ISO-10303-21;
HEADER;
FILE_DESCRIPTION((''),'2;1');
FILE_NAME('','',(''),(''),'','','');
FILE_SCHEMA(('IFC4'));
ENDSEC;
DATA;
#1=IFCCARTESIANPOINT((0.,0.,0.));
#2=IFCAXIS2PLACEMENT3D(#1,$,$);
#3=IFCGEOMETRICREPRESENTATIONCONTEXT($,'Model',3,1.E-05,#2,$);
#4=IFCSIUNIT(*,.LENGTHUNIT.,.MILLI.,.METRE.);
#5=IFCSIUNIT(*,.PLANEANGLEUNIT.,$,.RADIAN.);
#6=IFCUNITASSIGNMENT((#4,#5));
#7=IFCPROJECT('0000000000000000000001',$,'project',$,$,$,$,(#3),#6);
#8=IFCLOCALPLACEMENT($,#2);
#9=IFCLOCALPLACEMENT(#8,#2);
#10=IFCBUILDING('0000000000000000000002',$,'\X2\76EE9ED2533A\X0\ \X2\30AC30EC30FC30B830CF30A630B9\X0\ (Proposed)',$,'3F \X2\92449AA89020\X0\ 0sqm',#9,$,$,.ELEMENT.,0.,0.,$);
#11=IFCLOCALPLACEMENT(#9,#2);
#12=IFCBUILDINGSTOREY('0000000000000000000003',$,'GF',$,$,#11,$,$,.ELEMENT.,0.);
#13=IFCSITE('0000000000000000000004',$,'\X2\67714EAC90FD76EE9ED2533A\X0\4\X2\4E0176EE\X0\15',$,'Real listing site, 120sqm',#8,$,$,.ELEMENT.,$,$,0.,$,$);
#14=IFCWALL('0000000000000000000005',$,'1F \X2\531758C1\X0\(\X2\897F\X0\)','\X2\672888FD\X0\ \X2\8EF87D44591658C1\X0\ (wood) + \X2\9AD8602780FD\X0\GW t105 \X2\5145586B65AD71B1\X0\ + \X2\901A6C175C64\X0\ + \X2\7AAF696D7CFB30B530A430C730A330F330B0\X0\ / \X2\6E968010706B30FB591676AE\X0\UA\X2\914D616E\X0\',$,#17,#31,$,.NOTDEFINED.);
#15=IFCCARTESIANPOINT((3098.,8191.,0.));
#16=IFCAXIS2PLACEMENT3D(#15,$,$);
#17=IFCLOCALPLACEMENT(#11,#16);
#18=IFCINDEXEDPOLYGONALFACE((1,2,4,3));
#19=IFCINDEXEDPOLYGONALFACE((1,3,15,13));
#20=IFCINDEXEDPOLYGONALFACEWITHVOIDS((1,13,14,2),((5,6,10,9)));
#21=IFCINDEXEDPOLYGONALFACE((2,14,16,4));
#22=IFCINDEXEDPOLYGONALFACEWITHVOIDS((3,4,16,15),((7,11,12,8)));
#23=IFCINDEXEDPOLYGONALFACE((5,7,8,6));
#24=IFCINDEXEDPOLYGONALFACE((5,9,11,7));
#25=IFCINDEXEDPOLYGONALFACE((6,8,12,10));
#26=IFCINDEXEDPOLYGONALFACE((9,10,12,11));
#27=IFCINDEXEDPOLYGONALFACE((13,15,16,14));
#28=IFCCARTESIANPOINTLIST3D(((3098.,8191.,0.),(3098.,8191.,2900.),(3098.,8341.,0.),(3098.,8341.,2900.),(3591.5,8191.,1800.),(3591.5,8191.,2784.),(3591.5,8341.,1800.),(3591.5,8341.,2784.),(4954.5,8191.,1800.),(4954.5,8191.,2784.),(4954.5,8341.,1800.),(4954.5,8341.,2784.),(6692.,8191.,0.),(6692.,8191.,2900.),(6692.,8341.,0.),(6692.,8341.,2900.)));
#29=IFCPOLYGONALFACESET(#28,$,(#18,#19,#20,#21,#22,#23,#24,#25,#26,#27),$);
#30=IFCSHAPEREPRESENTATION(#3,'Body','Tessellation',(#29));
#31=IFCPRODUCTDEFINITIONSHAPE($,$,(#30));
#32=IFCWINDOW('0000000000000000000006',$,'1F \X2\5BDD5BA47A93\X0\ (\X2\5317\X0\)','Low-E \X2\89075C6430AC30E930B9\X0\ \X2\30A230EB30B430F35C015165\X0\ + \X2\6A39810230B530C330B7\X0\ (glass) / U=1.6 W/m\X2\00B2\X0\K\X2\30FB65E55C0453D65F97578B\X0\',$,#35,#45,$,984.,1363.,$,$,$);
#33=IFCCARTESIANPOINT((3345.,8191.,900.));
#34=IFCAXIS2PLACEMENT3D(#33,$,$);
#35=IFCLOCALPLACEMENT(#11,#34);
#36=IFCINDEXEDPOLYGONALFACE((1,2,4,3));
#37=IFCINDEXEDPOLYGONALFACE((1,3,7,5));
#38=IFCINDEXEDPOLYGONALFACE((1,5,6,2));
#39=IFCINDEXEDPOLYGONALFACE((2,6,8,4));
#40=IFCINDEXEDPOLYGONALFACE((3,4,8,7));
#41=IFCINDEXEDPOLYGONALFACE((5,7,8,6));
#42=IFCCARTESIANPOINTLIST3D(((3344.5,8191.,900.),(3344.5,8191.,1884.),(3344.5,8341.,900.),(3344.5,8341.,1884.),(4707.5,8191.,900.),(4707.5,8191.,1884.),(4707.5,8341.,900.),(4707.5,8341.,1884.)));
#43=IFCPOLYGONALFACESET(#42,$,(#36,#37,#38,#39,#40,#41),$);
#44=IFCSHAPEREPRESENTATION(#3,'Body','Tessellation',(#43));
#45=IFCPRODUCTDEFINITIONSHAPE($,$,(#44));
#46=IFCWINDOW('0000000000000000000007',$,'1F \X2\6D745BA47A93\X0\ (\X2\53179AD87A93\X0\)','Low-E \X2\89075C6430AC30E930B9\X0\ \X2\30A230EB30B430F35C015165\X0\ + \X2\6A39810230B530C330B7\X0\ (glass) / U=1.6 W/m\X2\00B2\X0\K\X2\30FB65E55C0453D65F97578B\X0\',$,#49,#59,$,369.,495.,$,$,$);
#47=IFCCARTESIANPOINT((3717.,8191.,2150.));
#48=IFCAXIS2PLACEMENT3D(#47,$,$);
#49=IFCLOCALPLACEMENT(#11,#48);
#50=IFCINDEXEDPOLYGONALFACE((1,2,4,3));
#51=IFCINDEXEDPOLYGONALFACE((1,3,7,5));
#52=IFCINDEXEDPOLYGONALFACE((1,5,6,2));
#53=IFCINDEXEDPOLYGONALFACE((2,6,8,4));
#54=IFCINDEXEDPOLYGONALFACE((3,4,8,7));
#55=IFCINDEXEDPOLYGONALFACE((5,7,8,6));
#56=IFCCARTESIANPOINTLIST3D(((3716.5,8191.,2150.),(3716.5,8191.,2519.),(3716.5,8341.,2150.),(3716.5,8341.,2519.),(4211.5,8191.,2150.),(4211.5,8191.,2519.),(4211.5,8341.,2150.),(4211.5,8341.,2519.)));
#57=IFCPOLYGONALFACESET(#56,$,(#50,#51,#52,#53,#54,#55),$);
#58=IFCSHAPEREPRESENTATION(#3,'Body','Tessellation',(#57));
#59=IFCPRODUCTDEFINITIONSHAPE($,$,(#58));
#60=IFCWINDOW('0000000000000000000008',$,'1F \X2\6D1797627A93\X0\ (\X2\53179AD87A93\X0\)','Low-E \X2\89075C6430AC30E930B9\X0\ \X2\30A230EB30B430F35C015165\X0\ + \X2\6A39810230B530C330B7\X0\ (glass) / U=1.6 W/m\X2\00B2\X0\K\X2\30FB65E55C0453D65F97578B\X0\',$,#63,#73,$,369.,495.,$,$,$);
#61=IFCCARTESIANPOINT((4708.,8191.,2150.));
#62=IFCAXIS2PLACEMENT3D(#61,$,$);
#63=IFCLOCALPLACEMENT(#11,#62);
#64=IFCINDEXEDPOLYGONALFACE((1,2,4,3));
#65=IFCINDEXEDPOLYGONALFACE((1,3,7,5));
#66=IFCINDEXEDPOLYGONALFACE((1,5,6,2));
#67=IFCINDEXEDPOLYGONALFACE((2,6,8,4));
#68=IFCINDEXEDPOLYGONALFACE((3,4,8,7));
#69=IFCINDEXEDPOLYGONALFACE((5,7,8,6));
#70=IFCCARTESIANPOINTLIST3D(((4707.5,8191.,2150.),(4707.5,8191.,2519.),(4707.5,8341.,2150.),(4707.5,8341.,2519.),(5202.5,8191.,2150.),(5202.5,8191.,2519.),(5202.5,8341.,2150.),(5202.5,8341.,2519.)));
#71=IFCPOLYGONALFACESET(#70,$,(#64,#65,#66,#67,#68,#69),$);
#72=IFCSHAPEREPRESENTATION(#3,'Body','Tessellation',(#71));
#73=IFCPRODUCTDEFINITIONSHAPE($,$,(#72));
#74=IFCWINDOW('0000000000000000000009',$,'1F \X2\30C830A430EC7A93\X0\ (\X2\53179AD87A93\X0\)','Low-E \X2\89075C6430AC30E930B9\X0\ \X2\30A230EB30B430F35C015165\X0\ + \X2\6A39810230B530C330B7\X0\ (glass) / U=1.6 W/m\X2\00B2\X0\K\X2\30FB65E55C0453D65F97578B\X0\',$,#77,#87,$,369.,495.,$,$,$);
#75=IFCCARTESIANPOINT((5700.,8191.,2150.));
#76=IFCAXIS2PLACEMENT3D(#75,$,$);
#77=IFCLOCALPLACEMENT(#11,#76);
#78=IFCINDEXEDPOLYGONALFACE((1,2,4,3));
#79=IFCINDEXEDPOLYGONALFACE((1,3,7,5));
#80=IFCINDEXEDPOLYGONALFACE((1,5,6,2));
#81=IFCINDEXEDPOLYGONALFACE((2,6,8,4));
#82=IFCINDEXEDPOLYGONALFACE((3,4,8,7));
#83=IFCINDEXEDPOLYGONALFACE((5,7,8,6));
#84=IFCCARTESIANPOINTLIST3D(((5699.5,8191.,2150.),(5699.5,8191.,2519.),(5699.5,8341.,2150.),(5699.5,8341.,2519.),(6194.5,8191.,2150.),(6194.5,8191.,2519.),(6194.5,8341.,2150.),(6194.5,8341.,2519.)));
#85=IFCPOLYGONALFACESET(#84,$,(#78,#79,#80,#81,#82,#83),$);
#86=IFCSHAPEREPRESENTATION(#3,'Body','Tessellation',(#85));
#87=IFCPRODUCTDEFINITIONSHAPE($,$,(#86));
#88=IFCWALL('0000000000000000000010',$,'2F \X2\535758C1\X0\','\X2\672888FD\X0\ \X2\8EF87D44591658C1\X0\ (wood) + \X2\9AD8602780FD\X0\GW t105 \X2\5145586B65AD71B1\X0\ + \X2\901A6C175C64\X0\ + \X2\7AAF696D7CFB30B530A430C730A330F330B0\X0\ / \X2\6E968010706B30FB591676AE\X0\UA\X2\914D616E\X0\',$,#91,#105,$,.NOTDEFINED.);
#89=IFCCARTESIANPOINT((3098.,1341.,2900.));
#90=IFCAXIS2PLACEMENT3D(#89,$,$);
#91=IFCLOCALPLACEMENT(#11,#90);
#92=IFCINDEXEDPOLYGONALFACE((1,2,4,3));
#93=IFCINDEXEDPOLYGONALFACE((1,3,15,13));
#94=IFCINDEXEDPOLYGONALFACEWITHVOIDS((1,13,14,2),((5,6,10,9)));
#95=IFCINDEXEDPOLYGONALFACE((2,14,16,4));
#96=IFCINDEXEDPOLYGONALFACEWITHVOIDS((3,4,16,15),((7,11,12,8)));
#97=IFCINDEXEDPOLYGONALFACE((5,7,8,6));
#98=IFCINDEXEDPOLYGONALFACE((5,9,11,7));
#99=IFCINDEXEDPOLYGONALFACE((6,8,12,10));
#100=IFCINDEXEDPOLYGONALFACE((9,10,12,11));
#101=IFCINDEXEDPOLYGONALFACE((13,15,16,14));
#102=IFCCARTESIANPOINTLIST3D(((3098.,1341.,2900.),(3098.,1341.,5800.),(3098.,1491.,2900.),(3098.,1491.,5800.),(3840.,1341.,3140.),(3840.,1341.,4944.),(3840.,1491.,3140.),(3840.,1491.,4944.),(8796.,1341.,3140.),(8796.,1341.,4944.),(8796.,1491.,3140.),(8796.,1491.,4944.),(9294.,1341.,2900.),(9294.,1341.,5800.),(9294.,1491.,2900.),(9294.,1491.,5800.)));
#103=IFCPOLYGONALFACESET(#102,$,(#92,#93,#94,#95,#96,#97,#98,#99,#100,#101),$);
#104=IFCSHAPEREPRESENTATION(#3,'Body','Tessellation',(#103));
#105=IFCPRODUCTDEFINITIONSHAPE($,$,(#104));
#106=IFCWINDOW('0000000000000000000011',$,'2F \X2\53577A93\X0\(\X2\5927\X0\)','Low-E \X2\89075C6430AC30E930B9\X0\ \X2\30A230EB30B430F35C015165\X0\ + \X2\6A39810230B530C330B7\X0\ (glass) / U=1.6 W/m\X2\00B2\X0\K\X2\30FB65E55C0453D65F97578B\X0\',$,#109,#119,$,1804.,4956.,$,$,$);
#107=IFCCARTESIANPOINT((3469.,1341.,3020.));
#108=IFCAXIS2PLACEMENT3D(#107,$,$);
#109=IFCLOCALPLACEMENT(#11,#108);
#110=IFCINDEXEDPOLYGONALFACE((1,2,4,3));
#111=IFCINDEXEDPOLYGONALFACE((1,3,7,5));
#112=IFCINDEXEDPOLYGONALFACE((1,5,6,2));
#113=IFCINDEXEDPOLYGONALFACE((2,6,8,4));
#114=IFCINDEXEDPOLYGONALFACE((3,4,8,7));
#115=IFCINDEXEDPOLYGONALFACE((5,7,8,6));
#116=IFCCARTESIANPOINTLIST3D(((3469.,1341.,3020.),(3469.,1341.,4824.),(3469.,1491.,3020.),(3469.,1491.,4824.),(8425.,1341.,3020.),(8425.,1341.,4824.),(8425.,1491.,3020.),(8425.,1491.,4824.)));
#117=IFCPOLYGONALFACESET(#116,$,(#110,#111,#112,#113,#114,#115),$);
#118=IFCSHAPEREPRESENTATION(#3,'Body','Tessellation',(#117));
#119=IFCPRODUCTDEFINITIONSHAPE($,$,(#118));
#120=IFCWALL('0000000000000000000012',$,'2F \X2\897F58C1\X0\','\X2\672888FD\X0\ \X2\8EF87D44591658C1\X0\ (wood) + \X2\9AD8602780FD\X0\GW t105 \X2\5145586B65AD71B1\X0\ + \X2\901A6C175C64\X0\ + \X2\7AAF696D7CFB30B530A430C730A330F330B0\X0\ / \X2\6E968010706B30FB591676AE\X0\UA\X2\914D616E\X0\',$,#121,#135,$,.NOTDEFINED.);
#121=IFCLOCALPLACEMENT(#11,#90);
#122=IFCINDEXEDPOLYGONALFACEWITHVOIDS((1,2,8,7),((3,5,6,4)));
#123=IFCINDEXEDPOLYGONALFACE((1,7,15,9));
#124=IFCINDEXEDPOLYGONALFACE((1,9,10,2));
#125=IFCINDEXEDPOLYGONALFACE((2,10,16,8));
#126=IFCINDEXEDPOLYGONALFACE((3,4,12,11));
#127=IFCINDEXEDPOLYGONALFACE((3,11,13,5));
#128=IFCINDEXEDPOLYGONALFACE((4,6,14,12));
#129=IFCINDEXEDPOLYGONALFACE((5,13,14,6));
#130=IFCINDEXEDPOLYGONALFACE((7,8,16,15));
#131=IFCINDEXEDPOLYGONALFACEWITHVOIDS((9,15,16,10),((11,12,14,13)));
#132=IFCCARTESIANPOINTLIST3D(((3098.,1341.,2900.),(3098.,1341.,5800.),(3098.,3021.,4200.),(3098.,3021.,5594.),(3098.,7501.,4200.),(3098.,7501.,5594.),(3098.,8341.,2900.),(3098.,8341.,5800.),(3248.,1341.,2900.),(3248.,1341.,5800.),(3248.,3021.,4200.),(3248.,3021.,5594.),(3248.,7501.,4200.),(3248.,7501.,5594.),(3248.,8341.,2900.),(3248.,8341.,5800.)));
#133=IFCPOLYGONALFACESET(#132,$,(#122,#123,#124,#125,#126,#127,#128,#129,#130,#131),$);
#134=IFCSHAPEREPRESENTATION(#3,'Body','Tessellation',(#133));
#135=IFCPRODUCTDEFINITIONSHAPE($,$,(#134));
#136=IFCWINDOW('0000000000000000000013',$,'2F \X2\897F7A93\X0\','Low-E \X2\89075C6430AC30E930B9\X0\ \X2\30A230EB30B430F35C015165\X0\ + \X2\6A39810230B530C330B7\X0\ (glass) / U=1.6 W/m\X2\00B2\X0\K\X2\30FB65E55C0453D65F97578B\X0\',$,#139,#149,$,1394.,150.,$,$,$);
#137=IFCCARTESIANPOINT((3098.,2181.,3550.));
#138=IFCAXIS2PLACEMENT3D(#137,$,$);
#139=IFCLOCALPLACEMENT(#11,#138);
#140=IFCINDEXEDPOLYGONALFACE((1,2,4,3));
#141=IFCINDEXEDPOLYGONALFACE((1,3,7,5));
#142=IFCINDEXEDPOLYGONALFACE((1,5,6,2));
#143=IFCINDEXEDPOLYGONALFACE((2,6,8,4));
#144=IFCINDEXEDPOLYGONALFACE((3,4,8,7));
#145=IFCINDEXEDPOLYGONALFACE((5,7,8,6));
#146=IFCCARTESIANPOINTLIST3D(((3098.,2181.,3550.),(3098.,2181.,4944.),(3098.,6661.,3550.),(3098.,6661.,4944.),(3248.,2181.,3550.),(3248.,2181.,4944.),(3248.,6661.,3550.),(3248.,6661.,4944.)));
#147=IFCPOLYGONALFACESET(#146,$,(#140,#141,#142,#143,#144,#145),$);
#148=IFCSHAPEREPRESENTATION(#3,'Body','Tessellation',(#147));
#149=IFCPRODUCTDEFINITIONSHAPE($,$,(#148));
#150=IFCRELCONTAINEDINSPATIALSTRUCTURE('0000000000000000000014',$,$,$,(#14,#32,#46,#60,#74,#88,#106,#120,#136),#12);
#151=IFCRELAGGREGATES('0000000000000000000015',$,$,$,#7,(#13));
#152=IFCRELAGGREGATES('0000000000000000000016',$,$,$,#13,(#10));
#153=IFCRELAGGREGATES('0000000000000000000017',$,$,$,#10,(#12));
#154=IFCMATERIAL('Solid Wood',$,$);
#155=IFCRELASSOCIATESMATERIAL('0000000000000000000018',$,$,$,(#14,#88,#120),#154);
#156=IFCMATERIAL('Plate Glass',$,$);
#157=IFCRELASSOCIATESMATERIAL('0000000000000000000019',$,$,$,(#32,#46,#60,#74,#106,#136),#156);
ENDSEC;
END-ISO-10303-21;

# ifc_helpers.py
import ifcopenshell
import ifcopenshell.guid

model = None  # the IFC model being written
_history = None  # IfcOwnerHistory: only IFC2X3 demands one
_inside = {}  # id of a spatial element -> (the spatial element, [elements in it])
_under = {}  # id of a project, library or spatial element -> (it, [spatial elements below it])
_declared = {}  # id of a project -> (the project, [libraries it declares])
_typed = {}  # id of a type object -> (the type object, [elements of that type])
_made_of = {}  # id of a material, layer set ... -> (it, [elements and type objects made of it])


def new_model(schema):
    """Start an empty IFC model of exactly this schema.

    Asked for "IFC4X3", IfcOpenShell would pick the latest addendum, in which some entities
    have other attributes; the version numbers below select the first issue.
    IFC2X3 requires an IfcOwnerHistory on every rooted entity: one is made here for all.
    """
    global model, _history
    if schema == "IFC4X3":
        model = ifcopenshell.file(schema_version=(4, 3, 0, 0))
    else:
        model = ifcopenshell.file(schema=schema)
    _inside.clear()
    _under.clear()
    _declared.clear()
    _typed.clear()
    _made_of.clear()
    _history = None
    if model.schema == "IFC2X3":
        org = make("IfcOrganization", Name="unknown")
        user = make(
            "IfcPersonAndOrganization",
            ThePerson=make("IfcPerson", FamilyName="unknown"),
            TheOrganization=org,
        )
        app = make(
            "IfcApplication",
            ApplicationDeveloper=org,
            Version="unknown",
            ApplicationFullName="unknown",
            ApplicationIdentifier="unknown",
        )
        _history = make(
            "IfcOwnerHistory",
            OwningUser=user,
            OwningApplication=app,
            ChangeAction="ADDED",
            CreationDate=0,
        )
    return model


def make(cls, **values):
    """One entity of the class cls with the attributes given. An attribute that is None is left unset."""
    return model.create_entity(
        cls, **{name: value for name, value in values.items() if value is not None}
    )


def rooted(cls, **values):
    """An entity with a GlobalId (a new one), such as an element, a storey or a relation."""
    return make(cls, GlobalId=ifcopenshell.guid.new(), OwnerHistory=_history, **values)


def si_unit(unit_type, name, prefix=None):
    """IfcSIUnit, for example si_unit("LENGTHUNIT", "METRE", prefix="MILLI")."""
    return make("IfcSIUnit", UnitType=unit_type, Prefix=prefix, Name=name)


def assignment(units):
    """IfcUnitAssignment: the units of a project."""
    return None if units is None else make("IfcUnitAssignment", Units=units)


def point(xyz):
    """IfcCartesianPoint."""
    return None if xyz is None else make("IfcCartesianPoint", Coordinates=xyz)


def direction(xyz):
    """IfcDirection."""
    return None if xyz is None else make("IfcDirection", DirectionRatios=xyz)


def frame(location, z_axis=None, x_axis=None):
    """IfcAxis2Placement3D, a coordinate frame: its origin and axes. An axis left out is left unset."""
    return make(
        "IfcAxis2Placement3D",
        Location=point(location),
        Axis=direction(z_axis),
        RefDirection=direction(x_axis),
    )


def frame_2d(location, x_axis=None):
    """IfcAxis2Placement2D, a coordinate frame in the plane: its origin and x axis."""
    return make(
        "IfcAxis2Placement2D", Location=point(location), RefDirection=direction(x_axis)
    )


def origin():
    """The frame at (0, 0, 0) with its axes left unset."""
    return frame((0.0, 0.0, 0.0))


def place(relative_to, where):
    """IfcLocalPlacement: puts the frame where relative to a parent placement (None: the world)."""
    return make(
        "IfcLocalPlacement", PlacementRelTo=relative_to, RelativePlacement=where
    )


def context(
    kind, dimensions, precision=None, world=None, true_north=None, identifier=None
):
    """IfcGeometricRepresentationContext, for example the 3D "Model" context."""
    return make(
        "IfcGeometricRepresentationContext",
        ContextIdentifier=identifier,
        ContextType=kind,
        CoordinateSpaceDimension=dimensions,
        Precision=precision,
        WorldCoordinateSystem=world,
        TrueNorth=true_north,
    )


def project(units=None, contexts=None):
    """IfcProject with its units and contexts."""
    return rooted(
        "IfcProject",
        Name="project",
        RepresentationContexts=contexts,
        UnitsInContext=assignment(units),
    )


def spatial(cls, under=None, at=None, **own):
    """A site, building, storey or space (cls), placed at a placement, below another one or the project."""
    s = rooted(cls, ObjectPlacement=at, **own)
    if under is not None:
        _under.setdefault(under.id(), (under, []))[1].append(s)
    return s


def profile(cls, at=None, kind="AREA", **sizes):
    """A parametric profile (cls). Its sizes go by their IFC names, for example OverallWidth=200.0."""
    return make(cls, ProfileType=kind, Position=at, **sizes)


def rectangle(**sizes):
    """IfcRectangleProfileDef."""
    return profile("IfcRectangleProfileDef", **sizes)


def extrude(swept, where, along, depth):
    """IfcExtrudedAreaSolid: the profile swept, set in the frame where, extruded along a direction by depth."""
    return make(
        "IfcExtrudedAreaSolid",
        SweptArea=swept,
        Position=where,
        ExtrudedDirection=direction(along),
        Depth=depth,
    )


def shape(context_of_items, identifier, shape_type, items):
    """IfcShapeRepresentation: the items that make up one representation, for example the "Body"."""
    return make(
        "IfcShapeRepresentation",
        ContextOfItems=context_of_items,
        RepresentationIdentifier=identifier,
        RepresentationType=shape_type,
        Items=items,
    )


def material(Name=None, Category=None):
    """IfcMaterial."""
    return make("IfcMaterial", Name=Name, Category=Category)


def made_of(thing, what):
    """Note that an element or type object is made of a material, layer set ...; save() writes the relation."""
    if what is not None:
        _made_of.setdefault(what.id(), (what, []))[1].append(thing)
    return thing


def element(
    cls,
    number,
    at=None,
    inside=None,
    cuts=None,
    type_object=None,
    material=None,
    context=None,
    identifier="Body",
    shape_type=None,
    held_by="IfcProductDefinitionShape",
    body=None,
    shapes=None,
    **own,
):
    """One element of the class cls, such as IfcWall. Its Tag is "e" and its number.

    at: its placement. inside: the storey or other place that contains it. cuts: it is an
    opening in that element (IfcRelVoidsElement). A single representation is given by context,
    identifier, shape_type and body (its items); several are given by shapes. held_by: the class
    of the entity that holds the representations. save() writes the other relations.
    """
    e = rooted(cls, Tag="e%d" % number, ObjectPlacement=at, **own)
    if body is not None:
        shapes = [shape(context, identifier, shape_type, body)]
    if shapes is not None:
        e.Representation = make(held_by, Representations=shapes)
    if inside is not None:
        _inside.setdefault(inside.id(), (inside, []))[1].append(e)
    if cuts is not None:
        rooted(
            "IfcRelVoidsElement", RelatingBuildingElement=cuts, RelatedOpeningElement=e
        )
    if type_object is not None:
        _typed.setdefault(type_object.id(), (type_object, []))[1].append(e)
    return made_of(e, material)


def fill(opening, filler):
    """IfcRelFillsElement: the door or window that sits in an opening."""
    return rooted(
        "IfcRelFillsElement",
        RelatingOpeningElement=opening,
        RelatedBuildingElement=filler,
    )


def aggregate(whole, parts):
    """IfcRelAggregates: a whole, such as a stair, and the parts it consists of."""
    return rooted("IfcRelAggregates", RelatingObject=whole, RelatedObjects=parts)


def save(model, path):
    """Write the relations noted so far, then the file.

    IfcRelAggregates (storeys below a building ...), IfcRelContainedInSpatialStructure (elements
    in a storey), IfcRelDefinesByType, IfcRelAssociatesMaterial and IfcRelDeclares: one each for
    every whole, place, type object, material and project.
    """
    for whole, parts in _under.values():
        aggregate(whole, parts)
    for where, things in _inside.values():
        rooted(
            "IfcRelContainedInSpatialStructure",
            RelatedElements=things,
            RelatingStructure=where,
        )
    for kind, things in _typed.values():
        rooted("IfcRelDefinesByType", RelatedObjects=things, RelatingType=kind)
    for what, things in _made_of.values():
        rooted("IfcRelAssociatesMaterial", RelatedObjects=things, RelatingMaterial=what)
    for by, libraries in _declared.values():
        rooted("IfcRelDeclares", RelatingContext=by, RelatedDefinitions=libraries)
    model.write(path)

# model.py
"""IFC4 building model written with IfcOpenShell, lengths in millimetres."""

from ifc_helpers import new_model, si_unit, frame, frame_2d, origin, place, context, project, spatial, rectangle, extrude, material, element, fill, save


model = new_model("IFC4")

# Units and contexts
model_context = context("Model", 3, precision=1e-05, world=origin())
ifc_project = project(units=[si_unit("LENGTHUNIT", "METRE", prefix="MILLI"), si_unit("PLANEANGLEUNIT", "RADIAN")], contexts=[model_context])

# Site, building, storey
site_placement = place(None, origin())
site = spatial("IfcSite", under=ifc_project, at=site_placement, Name="東京都目黒区4丁目15", ObjectType="Real listing site, 120sqm", CompositionType="ELEMENT", RefElevation=0.0)
building_placement = place(site_placement, origin())
building = spatial("IfcBuilding", under=site, at=building_placement, Name="目黒区 ガレージハウス (Proposed)", ObjectType="3F 鉄骨造 0sqm", CompositionType="ELEMENT", ElevationOfRefHeight=0.0, ElevationOfTerrain=0.0)
storey_placement = place(building_placement, origin())
storey = spatial("IfcBuildingStorey", under=building, at=storey_placement, Name="GF", CompositionType="ELEMENT", Elevation=0.0)

# Shared definitions
ifc_material_1 = material(Name="Solid Wood")

# Shared definitions
ifc_material_2 = material(Name="Plate Glass")

# Wall, openings, windows
wall_1_placement = place(storey_placement, frame((3098.0, 8191.0, 0.0)))
wall_1 = element("IfcWall", 1, at=wall_1_placement, inside=storey, material=ifc_material_1, Name="1F 北壁(西)", Description="木製 軸組外壁 (wood) + 高性能GW t105 充填断熱 + 通気層 + 窯業系サイディング / 準耐火・外皮UA配慮", PredefinedType="NOTDEFINED", context=model_context, shape_type="SweptSolid", body=[
    extrude(rectangle(XDim=3594.0, YDim=150.0, at=frame_2d((1797.0, 75.0))), frame((3098.0, 8191.0, 0.0)), (0.0, 0.0, 1.0), 2900.0),
])
opening_1_placement = place(storey_placement, frame((3345.0, 8191.0, 900.0)))
opening_1 = element("IfcOpeningElement", 2, at=opening_1_placement, cuts=wall_1, PredefinedType="NOTDEFINED", context=model_context, shape_type="SweptSolid", body=[
    extrude(rectangle(XDim=1363.0, YDim=150.0, at=frame_2d((681.0, 75.0))), frame((3345.0, 8191.0, 900.0)), (0.0, 0.0, 1.0), 984.0),
])
opening_2_placement = place(storey_placement, frame((3717.0, 8191.0, 2150.0)))
opening_2 = element("IfcOpeningElement", 3, at=opening_2_placement, cuts=wall_1, PredefinedType="NOTDEFINED", context=model_context, shape_type="SweptSolid", body=[
    extrude(rectangle(XDim=495.0, YDim=150.0, at=frame_2d((247.0, 75.0))), frame((3717.0, 8191.0, 2150.0)), (0.0, 0.0, 1.0), 369.0),
])
opening_3_placement = place(storey_placement, frame((4708.0, 8191.0, 2150.0)))
opening_3 = element("IfcOpeningElement", 4, at=opening_3_placement, cuts=wall_1, PredefinedType="NOTDEFINED", context=model_context, shape_type="SweptSolid", body=[
    extrude(rectangle(XDim=495.0, YDim=150.0, at=frame_2d((247.0, 75.0))), frame((4708.0, 8191.0, 2150.0)), (0.0, 0.0, 1.0), 369.0),
])
opening_4_placement = place(storey_placement, frame((5700.0, 8191.0, 2150.0)))
opening_4 = element("IfcOpeningElement", 5, at=opening_4_placement, cuts=wall_1, PredefinedType="NOTDEFINED", context=model_context, shape_type="SweptSolid", body=[
    extrude(rectangle(XDim=495.0, YDim=150.0, at=frame_2d((247.0, 75.0))), frame((5700.0, 8191.0, 2150.0)), (0.0, 0.0, 1.0), 369.0),
])
window_1_placement = place(storey_placement, frame((3345.0, 8191.0, 900.0)))
window_1 = element("IfcWindow", 6, at=window_1_placement, inside=storey, material=ifc_material_2, Name="1F 寝室窓 (北)", Description="Low-E 複層ガラス アルゴン封入 + 樹脂サッシ (glass) / U=1.6 W/m²K・日射取得型", OverallHeight=984.0, OverallWidth=1363.0, context=model_context, shape_type="SweptSolid", body=[
    extrude(rectangle(XDim=1363.0, YDim=150.0, at=frame_2d((681.0, 75.0))), frame((3345.0, 8191.0, 900.0)), (0.0, 0.0, 1.0), 984.0),
])
fill(opening_1, window_1)
window_2_placement = place(storey_placement, frame((3717.0, 8191.0, 2150.0)))
window_2 = element("IfcWindow", 7, at=window_2_placement, inside=storey, material=ifc_material_2, Name="1F 浴室窓 (北高窓)", Description="Low-E 複層ガラス アルゴン封入 + 樹脂サッシ (glass) / U=1.6 W/m²K・日射取得型", OverallHeight=369.0, OverallWidth=495.0, context=model_context, shape_type="SweptSolid", body=[
    extrude(rectangle(XDim=495.0, YDim=150.0, at=frame_2d((247.0, 75.0))), frame((3717.0, 8191.0, 2150.0)), (0.0, 0.0, 1.0), 369.0),
])
fill(opening_2, window_2)
window_3_placement = place(storey_placement, frame((4708.0, 8191.0, 2150.0)))
window_3 = element("IfcWindow", 8, at=window_3_placement, inside=storey, material=ifc_material_2, Name="1F 洗面窓 (北高窓)", Description="Low-E 複層ガラス アルゴン封入 + 樹脂サッシ (glass) / U=1.6 W/m²K・日射取得型", OverallHeight=369.0, OverallWidth=495.0, context=model_context, shape_type="SweptSolid", body=[
    extrude(rectangle(XDim=495.0, YDim=150.0, at=frame_2d((247.0, 75.0))), frame((4708.0, 8191.0, 2150.0)), (0.0, 0.0, 1.0), 369.0),
])
fill(opening_3, window_3)
window_4_placement = place(storey_placement, frame((5700.0, 8191.0, 2150.0)))
window_4 = element("IfcWindow", 9, at=window_4_placement, inside=storey, material=ifc_material_2, Name="1F トイレ窓 (北高窓)", Description="Low-E 複層ガラス アルゴン封入 + 樹脂サッシ (glass) / U=1.6 W/m²K・日射取得型", OverallHeight=369.0, OverallWidth=495.0, context=model_context, shape_type="SweptSolid", body=[
    extrude(rectangle(XDim=495.0, YDim=150.0, at=frame_2d((247.0, 75.0))), frame((5700.0, 8191.0, 2150.0)), (0.0, 0.0, 1.0), 369.0),
])
fill(opening_4, window_4)

# Walls, openings, windows
wall_2_placement = place(storey_placement, frame((3098.0, 1341.0, 2900.0)))
wall_2 = element("IfcWall", 10, at=wall_2_placement, inside=storey, material=ifc_material_1, Name="2F 南壁", Description="木製 軸組外壁 (wood) + 高性能GW t105 充填断熱 + 通気層 + 窯業系サイディング / 準耐火・外皮UA配慮", PredefinedType="NOTDEFINED", context=model_context, shape_type="SweptSolid", body=[
    extrude(rectangle(XDim=6196.0, YDim=150.0, at=frame_2d((3098.0, 75.0))), frame((3098.0, 1341.0, 2900.0)), (0.0, 0.0, 1.0), 2900.0),
])
opening_5_placement = place(storey_placement, frame((3469.0, 1341.0, 3020.0)))
opening_5 = element("IfcOpeningElement", 11, at=opening_5_placement, cuts=wall_2, PredefinedType="NOTDEFINED", context=model_context, shape_type="SweptSolid", body=[
    extrude(rectangle(XDim=4956.0, YDim=150.0, at=frame_2d((2478.0, 75.0))), frame((3469.0, 1341.0, 3020.0)), (0.0, 0.0, 1.0), 1804.0),
])
window_5_placement = place(storey_placement, frame((3469.0, 1341.0, 3020.0)))
window_5 = element("IfcWindow", 12, at=window_5_placement, inside=storey, material=ifc_material_2, Name="2F 南窓(大)", Description="Low-E 複層ガラス アルゴン封入 + 樹脂サッシ (glass) / U=1.6 W/m²K・日射取得型", OverallHeight=1804.0, OverallWidth=4956.0, context=model_context, shape_type="SweptSolid", body=[
    extrude(rectangle(XDim=4956.0, YDim=150.0, at=frame_2d((2478.0, 75.0))), frame((3469.0, 1341.0, 3020.0)), (0.0, 0.0, 1.0), 1804.0),
])
fill(opening_5, window_5)
wall_3_placement = place(storey_placement, frame((3098.0, 1341.0, 2900.0)))
wall_3 = element("IfcWall", 13, at=wall_3_placement, inside=storey, material=ifc_material_1, Name="2F 西壁", Description="木製 軸組外壁 (wood) + 高性能GW t105 充填断熱 + 通気層 + 窯業系サイディング / 準耐火・外皮UA配慮", PredefinedType="NOTDEFINED", context=model_context, shape_type="SweptSolid", body=[
    extrude(rectangle(XDim=150.0, YDim=7000.0, at=frame_2d((75.0, 3500.0))), frame((3098.0, 1341.0, 2900.0)), (0.0, 0.0, 1.0), 2900.0),
])
opening_6_placement = place(storey_placement, frame((3098.0, 2181.0, 3550.0)))
opening_6 = element("IfcOpeningElement", 14, at=opening_6_placement, cuts=wall_3, PredefinedType="NOTDEFINED", context=model_context, shape_type="SweptSolid", body=[
    extrude(rectangle(XDim=150.0, YDim=4480.0, at=frame_2d((75.0, 2240.0))), frame((3098.0, 2181.0, 3550.0)), (0.0, 0.0, 1.0), 1394.0),
])
window_6_placement = place(storey_placement, frame((3098.0, 2181.0, 3550.0)))
window_6 = element("IfcWindow", 15, at=window_6_placement, inside=storey, material=ifc_material_2, Name="2F 西窓", Description="Low-E 複層ガラス アルゴン封入 + 樹脂サッシ (glass) / U=1.6 W/m²K・日射取得型", OverallHeight=1394.0, OverallWidth=150.0, context=model_context, shape_type="SweptSolid", body=[
    extrude(rectangle(XDim=150.0, YDim=4480.0, at=frame_2d((75.0, 2240.0))), frame((3098.0, 2181.0, 3550.0)), (0.0, 0.0, 1.0), 1394.0),
])
fill(opening_6, window_6)

save(model, "model.ifc")
